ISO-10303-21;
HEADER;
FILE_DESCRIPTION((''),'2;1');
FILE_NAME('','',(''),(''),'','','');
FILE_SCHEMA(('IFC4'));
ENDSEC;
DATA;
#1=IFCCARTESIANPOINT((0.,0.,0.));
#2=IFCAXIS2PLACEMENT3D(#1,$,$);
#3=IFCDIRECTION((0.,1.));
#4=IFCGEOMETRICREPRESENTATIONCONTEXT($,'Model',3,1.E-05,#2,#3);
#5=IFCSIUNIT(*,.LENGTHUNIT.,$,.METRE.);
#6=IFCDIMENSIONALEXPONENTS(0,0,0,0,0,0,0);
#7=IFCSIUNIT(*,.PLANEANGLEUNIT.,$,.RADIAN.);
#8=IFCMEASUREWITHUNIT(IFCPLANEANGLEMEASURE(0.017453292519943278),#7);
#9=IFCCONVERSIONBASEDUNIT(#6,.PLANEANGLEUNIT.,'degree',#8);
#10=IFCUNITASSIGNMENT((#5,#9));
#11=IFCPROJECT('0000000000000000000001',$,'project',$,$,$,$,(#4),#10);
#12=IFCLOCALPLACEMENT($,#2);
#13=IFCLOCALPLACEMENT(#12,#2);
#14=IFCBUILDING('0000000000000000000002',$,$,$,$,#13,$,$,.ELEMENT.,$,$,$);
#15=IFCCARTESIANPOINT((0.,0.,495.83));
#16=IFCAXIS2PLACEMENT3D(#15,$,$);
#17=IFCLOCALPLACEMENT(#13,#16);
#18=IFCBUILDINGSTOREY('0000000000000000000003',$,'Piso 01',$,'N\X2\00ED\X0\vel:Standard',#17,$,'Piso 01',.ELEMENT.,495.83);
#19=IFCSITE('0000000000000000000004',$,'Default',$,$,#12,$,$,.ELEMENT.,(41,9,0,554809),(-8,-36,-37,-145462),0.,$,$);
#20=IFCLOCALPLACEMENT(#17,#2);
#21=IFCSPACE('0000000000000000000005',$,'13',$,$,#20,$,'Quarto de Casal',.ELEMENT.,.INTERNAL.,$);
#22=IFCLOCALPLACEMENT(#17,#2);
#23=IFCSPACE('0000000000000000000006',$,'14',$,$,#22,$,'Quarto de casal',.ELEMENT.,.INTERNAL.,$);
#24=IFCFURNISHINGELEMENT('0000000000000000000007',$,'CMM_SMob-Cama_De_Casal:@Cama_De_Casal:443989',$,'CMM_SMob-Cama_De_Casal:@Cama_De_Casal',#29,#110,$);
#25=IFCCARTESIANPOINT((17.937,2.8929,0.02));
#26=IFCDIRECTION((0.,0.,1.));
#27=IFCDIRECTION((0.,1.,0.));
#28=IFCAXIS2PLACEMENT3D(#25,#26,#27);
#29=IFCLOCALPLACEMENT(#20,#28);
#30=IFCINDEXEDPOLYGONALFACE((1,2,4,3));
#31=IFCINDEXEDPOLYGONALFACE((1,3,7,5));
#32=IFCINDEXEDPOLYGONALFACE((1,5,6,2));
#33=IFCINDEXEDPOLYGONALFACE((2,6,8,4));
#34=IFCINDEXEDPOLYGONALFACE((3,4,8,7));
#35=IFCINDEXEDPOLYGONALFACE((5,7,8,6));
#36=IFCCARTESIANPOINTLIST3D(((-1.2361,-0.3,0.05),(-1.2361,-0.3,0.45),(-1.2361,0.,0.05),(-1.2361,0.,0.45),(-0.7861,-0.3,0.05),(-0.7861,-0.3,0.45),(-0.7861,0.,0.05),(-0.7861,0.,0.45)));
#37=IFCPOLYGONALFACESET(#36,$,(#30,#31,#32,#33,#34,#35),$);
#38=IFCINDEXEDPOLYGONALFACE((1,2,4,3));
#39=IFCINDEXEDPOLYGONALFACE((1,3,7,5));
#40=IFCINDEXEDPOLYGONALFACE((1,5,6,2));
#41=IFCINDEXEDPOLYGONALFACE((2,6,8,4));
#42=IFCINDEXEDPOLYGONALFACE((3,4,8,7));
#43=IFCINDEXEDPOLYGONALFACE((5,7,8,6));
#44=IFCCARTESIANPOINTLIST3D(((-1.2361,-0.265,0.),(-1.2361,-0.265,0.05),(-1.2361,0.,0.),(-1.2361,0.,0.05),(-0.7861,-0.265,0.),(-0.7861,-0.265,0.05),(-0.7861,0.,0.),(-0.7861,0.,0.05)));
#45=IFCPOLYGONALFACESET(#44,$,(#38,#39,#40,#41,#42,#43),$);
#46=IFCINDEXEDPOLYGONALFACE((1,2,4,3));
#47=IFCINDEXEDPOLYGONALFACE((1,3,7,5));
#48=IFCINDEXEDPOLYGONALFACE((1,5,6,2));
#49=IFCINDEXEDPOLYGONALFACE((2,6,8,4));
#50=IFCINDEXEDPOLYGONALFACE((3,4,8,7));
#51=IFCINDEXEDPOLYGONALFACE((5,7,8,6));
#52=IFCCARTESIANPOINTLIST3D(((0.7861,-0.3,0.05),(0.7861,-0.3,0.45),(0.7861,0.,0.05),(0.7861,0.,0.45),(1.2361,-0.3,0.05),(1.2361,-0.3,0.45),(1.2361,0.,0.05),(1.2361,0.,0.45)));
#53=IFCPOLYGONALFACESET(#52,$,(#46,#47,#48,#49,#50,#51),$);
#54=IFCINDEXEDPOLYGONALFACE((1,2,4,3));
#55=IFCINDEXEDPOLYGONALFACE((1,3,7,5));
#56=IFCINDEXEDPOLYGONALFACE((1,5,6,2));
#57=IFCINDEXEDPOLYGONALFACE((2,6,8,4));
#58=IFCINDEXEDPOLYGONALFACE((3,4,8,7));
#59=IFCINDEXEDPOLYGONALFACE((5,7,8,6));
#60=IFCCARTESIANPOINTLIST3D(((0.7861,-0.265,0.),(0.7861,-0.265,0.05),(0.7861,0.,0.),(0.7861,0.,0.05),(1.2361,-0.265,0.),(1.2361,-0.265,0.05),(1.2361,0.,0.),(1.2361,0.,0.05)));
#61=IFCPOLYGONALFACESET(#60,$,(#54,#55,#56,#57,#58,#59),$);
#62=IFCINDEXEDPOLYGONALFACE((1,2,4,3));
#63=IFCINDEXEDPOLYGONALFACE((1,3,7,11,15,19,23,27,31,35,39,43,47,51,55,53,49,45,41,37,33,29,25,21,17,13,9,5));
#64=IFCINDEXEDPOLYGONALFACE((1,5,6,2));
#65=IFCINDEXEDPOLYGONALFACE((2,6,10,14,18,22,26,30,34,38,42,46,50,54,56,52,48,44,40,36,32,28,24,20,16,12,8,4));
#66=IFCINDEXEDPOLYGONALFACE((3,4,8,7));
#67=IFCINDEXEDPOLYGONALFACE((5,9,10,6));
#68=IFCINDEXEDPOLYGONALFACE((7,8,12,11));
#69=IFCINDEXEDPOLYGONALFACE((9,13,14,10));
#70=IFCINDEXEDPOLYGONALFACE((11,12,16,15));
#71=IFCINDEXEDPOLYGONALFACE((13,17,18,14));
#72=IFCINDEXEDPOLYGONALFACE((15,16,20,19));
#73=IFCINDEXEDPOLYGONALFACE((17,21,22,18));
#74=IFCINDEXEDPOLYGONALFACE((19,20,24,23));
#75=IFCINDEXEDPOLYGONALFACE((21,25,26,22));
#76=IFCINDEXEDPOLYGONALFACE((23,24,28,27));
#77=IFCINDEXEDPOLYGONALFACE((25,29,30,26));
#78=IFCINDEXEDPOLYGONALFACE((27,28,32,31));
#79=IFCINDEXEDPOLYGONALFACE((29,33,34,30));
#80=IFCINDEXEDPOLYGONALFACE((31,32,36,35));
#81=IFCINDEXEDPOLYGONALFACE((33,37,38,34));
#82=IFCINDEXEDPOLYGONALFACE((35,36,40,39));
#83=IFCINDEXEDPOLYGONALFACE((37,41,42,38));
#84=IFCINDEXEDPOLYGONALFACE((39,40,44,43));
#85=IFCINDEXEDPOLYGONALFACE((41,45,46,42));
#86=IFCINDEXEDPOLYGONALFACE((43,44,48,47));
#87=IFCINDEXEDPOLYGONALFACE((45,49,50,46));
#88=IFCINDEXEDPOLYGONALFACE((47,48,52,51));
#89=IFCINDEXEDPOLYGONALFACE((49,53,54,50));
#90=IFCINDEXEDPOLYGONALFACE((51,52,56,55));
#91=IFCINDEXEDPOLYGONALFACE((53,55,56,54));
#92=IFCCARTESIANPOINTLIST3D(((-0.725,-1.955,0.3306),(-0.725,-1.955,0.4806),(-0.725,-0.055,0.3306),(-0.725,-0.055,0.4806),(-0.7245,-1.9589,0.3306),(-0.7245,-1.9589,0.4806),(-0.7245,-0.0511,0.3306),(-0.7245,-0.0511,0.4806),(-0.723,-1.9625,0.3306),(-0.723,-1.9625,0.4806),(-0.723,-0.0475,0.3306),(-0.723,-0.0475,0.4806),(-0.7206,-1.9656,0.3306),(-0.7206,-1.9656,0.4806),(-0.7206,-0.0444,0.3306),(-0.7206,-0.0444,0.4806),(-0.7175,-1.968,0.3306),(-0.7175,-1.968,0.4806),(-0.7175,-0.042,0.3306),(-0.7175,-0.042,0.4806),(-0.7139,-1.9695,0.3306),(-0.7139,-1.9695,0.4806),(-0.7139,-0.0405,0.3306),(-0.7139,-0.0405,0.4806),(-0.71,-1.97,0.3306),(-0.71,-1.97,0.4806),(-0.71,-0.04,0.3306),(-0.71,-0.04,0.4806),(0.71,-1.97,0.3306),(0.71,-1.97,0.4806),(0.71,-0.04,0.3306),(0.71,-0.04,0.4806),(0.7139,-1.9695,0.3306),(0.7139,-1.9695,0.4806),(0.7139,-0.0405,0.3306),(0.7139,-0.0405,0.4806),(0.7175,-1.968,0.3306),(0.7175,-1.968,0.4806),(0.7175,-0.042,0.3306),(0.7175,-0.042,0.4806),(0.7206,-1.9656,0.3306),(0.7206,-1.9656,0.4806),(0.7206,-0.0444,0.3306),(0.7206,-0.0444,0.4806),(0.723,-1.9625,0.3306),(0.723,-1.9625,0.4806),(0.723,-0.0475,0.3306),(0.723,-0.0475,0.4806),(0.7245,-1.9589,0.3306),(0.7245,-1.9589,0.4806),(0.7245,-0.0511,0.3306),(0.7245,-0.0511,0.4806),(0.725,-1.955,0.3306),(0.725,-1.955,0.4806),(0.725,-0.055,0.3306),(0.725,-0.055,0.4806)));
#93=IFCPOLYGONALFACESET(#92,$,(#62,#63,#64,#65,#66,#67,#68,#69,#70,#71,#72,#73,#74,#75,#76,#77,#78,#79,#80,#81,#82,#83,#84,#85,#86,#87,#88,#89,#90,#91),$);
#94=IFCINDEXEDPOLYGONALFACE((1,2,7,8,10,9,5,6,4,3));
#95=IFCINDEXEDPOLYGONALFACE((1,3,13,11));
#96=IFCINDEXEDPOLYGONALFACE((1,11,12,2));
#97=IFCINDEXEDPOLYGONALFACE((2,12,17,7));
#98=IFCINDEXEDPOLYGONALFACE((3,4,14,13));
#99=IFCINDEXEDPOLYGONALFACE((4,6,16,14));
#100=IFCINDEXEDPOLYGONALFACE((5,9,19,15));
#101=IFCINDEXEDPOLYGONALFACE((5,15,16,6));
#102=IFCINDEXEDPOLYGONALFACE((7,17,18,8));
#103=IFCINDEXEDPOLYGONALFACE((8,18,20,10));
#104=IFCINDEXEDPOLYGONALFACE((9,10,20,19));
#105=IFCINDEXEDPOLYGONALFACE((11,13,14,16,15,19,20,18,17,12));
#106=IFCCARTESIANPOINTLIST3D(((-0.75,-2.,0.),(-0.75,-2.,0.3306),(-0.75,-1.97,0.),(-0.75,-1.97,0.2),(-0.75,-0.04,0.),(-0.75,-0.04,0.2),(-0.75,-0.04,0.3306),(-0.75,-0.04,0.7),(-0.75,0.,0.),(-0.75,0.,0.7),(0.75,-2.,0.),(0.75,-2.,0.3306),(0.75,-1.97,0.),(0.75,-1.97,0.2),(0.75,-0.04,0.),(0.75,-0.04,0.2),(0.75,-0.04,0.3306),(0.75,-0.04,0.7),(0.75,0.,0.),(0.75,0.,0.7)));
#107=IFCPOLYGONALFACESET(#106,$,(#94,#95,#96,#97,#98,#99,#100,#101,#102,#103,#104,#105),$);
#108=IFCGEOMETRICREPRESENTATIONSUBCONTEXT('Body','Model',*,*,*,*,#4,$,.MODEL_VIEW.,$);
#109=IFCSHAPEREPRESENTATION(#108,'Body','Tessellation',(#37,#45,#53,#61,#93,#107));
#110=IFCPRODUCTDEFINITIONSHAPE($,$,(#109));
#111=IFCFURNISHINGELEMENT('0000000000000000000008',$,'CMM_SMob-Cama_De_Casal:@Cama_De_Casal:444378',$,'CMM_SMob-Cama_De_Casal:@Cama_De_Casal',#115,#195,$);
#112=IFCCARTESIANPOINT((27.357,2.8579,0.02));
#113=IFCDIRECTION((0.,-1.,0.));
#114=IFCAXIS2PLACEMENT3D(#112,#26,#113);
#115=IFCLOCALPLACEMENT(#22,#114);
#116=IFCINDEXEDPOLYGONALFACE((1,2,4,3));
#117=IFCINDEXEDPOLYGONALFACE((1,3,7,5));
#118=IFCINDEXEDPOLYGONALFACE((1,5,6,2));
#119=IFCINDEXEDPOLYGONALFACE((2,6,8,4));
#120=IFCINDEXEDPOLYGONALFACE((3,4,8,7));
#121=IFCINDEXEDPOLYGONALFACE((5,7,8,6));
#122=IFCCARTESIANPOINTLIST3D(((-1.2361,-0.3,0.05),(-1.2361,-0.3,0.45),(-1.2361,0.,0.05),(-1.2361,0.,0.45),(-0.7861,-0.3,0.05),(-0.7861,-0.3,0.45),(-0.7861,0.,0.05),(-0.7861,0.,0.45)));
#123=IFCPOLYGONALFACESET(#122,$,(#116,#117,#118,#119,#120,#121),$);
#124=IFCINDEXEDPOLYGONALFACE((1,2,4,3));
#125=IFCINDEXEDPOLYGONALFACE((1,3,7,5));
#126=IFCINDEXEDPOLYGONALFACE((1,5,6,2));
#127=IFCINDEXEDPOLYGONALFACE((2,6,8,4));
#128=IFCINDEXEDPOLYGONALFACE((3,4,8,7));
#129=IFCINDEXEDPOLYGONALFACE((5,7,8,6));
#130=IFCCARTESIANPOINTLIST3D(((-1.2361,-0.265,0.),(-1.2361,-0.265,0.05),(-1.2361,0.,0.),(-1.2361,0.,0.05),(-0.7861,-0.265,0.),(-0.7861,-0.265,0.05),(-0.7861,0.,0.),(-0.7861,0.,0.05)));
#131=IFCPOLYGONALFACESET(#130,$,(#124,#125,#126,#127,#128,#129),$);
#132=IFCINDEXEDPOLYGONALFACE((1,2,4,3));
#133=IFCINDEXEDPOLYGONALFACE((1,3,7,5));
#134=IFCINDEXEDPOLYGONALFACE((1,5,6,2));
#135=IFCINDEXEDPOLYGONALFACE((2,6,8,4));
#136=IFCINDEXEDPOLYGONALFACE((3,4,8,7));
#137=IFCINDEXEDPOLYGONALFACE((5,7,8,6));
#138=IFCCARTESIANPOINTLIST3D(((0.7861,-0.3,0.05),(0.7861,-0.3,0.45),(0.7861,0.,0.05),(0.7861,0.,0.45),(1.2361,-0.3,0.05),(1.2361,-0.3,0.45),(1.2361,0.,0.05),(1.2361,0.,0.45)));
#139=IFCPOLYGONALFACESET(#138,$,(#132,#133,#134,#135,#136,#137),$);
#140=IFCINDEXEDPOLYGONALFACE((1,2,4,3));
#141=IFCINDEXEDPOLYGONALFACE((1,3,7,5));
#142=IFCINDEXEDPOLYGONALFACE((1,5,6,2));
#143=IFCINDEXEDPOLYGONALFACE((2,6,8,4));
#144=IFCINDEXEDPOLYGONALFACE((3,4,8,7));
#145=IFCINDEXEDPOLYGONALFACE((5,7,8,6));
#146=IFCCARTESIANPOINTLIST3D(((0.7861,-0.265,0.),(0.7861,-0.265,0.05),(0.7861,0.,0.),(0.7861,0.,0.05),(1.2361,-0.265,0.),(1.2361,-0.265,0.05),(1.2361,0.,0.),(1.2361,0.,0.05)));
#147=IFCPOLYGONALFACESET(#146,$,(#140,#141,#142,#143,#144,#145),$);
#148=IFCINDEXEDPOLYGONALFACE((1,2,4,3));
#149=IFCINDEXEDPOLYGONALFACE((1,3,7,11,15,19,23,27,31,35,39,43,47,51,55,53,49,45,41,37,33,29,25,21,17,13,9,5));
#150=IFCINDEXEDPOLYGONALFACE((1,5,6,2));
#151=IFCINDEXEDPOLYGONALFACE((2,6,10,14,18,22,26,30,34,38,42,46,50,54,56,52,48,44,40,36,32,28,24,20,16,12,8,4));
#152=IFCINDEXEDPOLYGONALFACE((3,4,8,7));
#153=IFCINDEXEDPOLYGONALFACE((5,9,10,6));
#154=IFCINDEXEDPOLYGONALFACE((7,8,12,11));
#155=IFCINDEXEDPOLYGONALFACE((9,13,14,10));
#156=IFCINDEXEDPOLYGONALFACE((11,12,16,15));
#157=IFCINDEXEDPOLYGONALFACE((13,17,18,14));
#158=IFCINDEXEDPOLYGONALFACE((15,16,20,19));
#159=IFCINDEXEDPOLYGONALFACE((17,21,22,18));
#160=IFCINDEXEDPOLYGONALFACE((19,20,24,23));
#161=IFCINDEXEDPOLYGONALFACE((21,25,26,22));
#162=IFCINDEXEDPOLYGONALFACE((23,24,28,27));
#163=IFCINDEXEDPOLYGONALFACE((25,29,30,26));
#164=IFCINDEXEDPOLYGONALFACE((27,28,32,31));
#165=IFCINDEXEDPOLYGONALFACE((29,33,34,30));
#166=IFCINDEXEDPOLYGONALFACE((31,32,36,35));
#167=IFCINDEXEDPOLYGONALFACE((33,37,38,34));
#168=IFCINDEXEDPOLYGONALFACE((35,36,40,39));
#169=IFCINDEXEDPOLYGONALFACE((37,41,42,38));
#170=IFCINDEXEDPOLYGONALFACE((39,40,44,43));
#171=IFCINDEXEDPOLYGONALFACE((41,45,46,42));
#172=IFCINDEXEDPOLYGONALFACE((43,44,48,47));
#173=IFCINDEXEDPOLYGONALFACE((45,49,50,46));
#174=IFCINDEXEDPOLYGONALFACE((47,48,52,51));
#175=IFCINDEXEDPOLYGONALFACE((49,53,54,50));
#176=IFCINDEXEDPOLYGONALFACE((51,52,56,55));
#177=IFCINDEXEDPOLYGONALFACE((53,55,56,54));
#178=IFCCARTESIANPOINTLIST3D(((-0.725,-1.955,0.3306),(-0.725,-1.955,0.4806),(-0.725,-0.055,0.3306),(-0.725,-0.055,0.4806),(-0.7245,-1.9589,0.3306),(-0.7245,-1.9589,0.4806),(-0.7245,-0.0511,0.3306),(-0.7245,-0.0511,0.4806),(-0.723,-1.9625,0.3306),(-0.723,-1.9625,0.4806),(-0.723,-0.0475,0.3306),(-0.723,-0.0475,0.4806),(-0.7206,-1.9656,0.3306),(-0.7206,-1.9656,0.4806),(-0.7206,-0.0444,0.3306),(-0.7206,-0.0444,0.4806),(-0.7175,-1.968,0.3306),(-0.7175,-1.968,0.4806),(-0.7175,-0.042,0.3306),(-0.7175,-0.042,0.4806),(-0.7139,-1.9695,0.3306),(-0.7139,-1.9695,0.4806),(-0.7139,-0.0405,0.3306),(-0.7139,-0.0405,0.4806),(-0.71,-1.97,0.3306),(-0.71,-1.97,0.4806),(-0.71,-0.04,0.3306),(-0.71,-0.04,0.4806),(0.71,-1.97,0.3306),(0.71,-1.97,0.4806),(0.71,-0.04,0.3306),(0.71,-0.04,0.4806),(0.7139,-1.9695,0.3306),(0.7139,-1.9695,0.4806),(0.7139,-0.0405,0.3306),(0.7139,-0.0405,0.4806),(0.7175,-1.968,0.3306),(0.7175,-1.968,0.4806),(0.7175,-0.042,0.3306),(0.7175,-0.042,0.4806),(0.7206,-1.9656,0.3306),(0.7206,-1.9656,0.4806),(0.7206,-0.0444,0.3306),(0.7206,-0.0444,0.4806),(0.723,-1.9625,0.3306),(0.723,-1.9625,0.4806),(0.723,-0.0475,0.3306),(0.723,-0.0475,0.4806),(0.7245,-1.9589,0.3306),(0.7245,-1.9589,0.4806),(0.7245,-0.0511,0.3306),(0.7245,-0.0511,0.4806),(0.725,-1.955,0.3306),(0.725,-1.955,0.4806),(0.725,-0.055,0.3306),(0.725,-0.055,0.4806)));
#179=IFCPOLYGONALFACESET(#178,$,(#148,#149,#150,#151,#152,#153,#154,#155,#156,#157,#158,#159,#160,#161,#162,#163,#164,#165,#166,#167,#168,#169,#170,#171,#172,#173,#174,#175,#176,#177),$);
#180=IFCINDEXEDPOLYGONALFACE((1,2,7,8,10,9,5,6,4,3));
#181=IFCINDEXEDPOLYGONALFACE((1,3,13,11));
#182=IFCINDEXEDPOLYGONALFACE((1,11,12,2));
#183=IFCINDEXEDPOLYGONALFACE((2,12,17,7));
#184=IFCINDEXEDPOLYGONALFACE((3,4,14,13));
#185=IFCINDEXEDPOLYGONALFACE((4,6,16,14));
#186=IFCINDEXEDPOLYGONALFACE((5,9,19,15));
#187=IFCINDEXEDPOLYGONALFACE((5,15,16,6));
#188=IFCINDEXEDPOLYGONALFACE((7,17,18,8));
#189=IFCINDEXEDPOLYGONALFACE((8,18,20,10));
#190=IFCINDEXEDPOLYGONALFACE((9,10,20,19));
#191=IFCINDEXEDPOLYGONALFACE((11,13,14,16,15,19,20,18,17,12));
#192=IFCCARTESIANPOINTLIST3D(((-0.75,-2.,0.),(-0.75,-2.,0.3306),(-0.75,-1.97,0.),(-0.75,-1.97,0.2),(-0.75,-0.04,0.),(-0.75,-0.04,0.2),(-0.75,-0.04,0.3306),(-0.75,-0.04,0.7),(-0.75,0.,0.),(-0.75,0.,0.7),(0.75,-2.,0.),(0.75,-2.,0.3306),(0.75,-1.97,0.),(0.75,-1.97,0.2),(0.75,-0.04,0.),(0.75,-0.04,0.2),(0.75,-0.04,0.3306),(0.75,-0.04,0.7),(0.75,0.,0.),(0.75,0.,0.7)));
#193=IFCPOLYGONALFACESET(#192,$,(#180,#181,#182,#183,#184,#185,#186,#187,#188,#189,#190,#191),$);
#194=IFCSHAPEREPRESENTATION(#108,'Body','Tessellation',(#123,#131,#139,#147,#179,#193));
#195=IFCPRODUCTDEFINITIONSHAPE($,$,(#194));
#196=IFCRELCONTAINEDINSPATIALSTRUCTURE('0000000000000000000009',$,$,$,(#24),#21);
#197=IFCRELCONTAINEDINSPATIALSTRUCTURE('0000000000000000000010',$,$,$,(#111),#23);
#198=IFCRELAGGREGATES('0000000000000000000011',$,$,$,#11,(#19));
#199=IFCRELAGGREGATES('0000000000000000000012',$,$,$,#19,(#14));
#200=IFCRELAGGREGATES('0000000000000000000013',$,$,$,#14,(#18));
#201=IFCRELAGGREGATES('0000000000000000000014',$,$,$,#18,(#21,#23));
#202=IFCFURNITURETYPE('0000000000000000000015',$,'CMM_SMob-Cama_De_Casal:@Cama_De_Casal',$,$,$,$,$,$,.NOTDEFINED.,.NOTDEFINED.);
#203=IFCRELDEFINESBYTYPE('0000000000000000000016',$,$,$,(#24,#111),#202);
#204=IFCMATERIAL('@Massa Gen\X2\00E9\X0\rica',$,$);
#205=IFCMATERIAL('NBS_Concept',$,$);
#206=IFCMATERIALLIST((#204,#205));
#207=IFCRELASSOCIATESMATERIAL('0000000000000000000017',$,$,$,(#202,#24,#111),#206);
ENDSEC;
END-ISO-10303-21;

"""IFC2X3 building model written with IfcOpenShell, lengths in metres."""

from ifc_helpers import new_model, entity, si_unit, converted_unit, direction, frame, frame_2d, origin, origin_2d_with_axis, place, context, subcontext, project, spatial, polyline, circle_curve, parameter, trimmed, segment, composite_curve, rectangle, outline, extrude, source, transform, mapped, material, material_list, type_object, type_shapes, element, save


model = new_model("IFC2X3")

# Units and contexts
model_context = context("Model", 3, precision=1e-05, world=origin(), true_north=direction((0.0, 1.0)))
body_context = subcontext(model_context, "Body", "Model", "MODEL_VIEW")
ifc_project = project(units=[si_unit("LENGTHUNIT", "METRE"), converted_unit("PLANEANGLEUNIT", "degree", entity("IfcPlaneAngleMeasure", 0.017453292519943278), si_unit("PLANEANGLEUNIT", "RADIAN"), dimensions=[0, 0, 0, 0, 0, 0, 0])], contexts=[model_context])

# Site, building, storey
site_placement = place(None, origin())
site = spatial("IfcSite", under=ifc_project, at=site_placement, Name="Default", CompositionType="ELEMENT", RefLatitude=(41, 9, 0, 554809), RefLongitude=(-8, -36, -37, -145462), RefElevation=0.0)
building_placement = place(site_placement, origin())
building = spatial("IfcBuilding", under=site, at=building_placement, CompositionType="ELEMENT")
storey_placement = place(building_placement, frame((0.0, 0.0, 495.83)))
storey = spatial("IfcBuildingStorey", under=building, at=storey_placement, Name="Piso 01", ObjectType="Nível:Standard", LongName="Piso 01", CompositionType="ELEMENT", Elevation=495.83)

# Shared definitions
ifc_material_1 = material(Name="NBS_Concept")

# Shared definitions
ifc_material_2 = material(Name="@Massa Genérica")
ifc_material_list = material_list([ifc_material_2, ifc_material_1])
furniture_type_1 = type_object("IfcFurnitureType", Name="CMM_SMob-Cama_De_Casal:@Cama_De_Casal", AssemblyPlace="NOTDEFINED", material=ifc_material_list)
shared_shape_1 = source(origin(), body_context, "Body", "SweptSolid", [
    extrude(rectangle(XDim=0.3, YDim=0.45, at=frame_2d((0.0, 0.0), x_axis=(1.0, 0.0))), frame((-1.0111, -0.15, 0.05), z_axis=(0.0, 0.0, 1.0), x_axis=(0.0, 1.0, 0.0)), (0.0, 0.0, 1.0), 0.4),
    extrude(rectangle(XDim=0.265, YDim=0.45, at=frame_2d((0.0, 0.0), x_axis=(1.0, 0.0))), frame((-1.0111, -0.1325, 0.0), z_axis=(0.0, 0.0, 1.0), x_axis=(0.0, -1.0, 0.0)), (0.0, 0.0, 1.0), 0.05),
    extrude(rectangle(XDim=0.45, YDim=0.3, at=origin_2d_with_axis()), frame((1.0111, -0.15, 0.05)), (0.0, 0.0, 1.0), 0.4),
    extrude(rectangle(XDim=0.45, YDim=0.265, at=origin_2d_with_axis()), frame((1.0111, -0.1325, 0.0), z_axis=(0.0, 0.0, 1.0), x_axis=(-1.0, 0.0, 0.0)), (0.0, 0.0, 1.0), 0.05),
    extrude(outline(composite_curve([segment(polyline([(-0.71, -0.965), (0.71, -0.965)]), True, "CONTINUOUS"), segment(trimmed(circle_curve(frame_2d((0.71, -0.95), x_axis=(-1.0, 0.0)), 0.015), [parameter(90.0)], [parameter(180.0)], True, "PARAMETER"), True, "CONTINUOUS"), segment(polyline([(0.725, -0.95), (0.725, 0.95)]), True, "CONTINUOUS"), segment(trimmed(circle_curve(frame_2d((0.71, 0.95), x_axis=(-1.0, 0.0)), 0.015), [parameter(180.0)], [parameter(270.0)], True, "PARAMETER"), True, "CONTINUOUS"), segment(polyline([(0.71, 0.965), (-0.71, 0.965)]), True, "CONTINUOUS"), segment(trimmed(circle_curve(frame_2d((-0.71, 0.95), x_axis=(-1.0, 0.0)), 0.015), [parameter(270.0)], [parameter(0.0)], True, "PARAMETER"), True, "CONTINUOUS"), segment(polyline([(-0.725, 0.95), (-0.725, -0.95)]), True, "CONTINUOUS"), segment(trimmed(circle_curve(frame_2d((-0.71, -0.95), x_axis=(-1.0, 0.0)), 0.015), [parameter(0.0)], [parameter(90.0)], True, "PARAMETER"), True, "CONTINUOUS")], self_intersect=False)), frame((0.0, -1.005, 0.3306), z_axis=(0.0, 0.0, 1.0), x_axis=(-1.0, 0.0, 0.0)), (0.0, 0.0, 1.0), 0.15),
    extrude(outline(polyline([(-0.2461, -1.16), (-0.2461, -1.19), (0.0845, -1.19), (0.0845, 0.77), (0.4539, 0.77), (0.4539, 0.81), (-0.2461, 0.81), (-0.2461, 0.77), (-0.0461, 0.77), (-0.0461, -1.16), (-0.2461, -1.16)])), frame((-0.75, -0.81, 0.2461), z_axis=(-1.0, 0.0, 0.0), x_axis=(0.0, 0.0, 1.0)), (0.0, 0.0, -1.0), 1.5),
])
type_shapes(furniture_type_1, [shared_shape_1])

# Shared definitions
space_1_placement = place(storey_placement, origin())
space_1 = spatial("IfcSpace", under=storey, at=space_1_placement, Name="13", LongName="Quarto de Casal", CompositionType="ELEMENT", InteriorOrExteriorSpace="INTERNAL")

# Furnishing element
furnishing_1_placement = place(space_1_placement, frame((17.937, 2.8929, 0.02), z_axis=(0.0, 0.0, 1.0), x_axis=(0.0, 1.0, 0.0)))
element("IfcFurnishingElement", 1, at=furnishing_1_placement, inside=space_1, type_object=furniture_type_1, material=ifc_material_list, Name="CMM_SMob-Cama_De_Casal:@Cama_De_Casal:443989", ObjectType="CMM_SMob-Cama_De_Casal:@Cama_De_Casal", context=body_context, shape_type="MappedRepresentation", body=[
    mapped(shared_shape_1, transform((0.0, 0.0, 0.0), scale=1.0)),
])

# Shared definitions
space_2_placement = place(storey_placement, origin())
space_2 = spatial("IfcSpace", under=storey, at=space_2_placement, Name="14", LongName="Quarto de casal", CompositionType="ELEMENT", InteriorOrExteriorSpace="INTERNAL")

# Furnishing element
furnishing_2_placement = place(space_2_placement, frame((27.357, 2.8579, 0.02), z_axis=(0.0, 0.0, 1.0), x_axis=(0.0, -1.0, 0.0)))
element("IfcFurnishingElement", 2, at=furnishing_2_placement, inside=space_2, type_object=furniture_type_1, material=ifc_material_list, Name="CMM_SMob-Cama_De_Casal:@Cama_De_Casal:444378", ObjectType="CMM_SMob-Cama_De_Casal:@Cama_De_Casal", context=body_context, shape_type="MappedRepresentation", body=[
    mapped(shared_shape_1, transform((0.0, 0.0, 0.0), scale=1.0)),
])

save(model, "model.ifc")
